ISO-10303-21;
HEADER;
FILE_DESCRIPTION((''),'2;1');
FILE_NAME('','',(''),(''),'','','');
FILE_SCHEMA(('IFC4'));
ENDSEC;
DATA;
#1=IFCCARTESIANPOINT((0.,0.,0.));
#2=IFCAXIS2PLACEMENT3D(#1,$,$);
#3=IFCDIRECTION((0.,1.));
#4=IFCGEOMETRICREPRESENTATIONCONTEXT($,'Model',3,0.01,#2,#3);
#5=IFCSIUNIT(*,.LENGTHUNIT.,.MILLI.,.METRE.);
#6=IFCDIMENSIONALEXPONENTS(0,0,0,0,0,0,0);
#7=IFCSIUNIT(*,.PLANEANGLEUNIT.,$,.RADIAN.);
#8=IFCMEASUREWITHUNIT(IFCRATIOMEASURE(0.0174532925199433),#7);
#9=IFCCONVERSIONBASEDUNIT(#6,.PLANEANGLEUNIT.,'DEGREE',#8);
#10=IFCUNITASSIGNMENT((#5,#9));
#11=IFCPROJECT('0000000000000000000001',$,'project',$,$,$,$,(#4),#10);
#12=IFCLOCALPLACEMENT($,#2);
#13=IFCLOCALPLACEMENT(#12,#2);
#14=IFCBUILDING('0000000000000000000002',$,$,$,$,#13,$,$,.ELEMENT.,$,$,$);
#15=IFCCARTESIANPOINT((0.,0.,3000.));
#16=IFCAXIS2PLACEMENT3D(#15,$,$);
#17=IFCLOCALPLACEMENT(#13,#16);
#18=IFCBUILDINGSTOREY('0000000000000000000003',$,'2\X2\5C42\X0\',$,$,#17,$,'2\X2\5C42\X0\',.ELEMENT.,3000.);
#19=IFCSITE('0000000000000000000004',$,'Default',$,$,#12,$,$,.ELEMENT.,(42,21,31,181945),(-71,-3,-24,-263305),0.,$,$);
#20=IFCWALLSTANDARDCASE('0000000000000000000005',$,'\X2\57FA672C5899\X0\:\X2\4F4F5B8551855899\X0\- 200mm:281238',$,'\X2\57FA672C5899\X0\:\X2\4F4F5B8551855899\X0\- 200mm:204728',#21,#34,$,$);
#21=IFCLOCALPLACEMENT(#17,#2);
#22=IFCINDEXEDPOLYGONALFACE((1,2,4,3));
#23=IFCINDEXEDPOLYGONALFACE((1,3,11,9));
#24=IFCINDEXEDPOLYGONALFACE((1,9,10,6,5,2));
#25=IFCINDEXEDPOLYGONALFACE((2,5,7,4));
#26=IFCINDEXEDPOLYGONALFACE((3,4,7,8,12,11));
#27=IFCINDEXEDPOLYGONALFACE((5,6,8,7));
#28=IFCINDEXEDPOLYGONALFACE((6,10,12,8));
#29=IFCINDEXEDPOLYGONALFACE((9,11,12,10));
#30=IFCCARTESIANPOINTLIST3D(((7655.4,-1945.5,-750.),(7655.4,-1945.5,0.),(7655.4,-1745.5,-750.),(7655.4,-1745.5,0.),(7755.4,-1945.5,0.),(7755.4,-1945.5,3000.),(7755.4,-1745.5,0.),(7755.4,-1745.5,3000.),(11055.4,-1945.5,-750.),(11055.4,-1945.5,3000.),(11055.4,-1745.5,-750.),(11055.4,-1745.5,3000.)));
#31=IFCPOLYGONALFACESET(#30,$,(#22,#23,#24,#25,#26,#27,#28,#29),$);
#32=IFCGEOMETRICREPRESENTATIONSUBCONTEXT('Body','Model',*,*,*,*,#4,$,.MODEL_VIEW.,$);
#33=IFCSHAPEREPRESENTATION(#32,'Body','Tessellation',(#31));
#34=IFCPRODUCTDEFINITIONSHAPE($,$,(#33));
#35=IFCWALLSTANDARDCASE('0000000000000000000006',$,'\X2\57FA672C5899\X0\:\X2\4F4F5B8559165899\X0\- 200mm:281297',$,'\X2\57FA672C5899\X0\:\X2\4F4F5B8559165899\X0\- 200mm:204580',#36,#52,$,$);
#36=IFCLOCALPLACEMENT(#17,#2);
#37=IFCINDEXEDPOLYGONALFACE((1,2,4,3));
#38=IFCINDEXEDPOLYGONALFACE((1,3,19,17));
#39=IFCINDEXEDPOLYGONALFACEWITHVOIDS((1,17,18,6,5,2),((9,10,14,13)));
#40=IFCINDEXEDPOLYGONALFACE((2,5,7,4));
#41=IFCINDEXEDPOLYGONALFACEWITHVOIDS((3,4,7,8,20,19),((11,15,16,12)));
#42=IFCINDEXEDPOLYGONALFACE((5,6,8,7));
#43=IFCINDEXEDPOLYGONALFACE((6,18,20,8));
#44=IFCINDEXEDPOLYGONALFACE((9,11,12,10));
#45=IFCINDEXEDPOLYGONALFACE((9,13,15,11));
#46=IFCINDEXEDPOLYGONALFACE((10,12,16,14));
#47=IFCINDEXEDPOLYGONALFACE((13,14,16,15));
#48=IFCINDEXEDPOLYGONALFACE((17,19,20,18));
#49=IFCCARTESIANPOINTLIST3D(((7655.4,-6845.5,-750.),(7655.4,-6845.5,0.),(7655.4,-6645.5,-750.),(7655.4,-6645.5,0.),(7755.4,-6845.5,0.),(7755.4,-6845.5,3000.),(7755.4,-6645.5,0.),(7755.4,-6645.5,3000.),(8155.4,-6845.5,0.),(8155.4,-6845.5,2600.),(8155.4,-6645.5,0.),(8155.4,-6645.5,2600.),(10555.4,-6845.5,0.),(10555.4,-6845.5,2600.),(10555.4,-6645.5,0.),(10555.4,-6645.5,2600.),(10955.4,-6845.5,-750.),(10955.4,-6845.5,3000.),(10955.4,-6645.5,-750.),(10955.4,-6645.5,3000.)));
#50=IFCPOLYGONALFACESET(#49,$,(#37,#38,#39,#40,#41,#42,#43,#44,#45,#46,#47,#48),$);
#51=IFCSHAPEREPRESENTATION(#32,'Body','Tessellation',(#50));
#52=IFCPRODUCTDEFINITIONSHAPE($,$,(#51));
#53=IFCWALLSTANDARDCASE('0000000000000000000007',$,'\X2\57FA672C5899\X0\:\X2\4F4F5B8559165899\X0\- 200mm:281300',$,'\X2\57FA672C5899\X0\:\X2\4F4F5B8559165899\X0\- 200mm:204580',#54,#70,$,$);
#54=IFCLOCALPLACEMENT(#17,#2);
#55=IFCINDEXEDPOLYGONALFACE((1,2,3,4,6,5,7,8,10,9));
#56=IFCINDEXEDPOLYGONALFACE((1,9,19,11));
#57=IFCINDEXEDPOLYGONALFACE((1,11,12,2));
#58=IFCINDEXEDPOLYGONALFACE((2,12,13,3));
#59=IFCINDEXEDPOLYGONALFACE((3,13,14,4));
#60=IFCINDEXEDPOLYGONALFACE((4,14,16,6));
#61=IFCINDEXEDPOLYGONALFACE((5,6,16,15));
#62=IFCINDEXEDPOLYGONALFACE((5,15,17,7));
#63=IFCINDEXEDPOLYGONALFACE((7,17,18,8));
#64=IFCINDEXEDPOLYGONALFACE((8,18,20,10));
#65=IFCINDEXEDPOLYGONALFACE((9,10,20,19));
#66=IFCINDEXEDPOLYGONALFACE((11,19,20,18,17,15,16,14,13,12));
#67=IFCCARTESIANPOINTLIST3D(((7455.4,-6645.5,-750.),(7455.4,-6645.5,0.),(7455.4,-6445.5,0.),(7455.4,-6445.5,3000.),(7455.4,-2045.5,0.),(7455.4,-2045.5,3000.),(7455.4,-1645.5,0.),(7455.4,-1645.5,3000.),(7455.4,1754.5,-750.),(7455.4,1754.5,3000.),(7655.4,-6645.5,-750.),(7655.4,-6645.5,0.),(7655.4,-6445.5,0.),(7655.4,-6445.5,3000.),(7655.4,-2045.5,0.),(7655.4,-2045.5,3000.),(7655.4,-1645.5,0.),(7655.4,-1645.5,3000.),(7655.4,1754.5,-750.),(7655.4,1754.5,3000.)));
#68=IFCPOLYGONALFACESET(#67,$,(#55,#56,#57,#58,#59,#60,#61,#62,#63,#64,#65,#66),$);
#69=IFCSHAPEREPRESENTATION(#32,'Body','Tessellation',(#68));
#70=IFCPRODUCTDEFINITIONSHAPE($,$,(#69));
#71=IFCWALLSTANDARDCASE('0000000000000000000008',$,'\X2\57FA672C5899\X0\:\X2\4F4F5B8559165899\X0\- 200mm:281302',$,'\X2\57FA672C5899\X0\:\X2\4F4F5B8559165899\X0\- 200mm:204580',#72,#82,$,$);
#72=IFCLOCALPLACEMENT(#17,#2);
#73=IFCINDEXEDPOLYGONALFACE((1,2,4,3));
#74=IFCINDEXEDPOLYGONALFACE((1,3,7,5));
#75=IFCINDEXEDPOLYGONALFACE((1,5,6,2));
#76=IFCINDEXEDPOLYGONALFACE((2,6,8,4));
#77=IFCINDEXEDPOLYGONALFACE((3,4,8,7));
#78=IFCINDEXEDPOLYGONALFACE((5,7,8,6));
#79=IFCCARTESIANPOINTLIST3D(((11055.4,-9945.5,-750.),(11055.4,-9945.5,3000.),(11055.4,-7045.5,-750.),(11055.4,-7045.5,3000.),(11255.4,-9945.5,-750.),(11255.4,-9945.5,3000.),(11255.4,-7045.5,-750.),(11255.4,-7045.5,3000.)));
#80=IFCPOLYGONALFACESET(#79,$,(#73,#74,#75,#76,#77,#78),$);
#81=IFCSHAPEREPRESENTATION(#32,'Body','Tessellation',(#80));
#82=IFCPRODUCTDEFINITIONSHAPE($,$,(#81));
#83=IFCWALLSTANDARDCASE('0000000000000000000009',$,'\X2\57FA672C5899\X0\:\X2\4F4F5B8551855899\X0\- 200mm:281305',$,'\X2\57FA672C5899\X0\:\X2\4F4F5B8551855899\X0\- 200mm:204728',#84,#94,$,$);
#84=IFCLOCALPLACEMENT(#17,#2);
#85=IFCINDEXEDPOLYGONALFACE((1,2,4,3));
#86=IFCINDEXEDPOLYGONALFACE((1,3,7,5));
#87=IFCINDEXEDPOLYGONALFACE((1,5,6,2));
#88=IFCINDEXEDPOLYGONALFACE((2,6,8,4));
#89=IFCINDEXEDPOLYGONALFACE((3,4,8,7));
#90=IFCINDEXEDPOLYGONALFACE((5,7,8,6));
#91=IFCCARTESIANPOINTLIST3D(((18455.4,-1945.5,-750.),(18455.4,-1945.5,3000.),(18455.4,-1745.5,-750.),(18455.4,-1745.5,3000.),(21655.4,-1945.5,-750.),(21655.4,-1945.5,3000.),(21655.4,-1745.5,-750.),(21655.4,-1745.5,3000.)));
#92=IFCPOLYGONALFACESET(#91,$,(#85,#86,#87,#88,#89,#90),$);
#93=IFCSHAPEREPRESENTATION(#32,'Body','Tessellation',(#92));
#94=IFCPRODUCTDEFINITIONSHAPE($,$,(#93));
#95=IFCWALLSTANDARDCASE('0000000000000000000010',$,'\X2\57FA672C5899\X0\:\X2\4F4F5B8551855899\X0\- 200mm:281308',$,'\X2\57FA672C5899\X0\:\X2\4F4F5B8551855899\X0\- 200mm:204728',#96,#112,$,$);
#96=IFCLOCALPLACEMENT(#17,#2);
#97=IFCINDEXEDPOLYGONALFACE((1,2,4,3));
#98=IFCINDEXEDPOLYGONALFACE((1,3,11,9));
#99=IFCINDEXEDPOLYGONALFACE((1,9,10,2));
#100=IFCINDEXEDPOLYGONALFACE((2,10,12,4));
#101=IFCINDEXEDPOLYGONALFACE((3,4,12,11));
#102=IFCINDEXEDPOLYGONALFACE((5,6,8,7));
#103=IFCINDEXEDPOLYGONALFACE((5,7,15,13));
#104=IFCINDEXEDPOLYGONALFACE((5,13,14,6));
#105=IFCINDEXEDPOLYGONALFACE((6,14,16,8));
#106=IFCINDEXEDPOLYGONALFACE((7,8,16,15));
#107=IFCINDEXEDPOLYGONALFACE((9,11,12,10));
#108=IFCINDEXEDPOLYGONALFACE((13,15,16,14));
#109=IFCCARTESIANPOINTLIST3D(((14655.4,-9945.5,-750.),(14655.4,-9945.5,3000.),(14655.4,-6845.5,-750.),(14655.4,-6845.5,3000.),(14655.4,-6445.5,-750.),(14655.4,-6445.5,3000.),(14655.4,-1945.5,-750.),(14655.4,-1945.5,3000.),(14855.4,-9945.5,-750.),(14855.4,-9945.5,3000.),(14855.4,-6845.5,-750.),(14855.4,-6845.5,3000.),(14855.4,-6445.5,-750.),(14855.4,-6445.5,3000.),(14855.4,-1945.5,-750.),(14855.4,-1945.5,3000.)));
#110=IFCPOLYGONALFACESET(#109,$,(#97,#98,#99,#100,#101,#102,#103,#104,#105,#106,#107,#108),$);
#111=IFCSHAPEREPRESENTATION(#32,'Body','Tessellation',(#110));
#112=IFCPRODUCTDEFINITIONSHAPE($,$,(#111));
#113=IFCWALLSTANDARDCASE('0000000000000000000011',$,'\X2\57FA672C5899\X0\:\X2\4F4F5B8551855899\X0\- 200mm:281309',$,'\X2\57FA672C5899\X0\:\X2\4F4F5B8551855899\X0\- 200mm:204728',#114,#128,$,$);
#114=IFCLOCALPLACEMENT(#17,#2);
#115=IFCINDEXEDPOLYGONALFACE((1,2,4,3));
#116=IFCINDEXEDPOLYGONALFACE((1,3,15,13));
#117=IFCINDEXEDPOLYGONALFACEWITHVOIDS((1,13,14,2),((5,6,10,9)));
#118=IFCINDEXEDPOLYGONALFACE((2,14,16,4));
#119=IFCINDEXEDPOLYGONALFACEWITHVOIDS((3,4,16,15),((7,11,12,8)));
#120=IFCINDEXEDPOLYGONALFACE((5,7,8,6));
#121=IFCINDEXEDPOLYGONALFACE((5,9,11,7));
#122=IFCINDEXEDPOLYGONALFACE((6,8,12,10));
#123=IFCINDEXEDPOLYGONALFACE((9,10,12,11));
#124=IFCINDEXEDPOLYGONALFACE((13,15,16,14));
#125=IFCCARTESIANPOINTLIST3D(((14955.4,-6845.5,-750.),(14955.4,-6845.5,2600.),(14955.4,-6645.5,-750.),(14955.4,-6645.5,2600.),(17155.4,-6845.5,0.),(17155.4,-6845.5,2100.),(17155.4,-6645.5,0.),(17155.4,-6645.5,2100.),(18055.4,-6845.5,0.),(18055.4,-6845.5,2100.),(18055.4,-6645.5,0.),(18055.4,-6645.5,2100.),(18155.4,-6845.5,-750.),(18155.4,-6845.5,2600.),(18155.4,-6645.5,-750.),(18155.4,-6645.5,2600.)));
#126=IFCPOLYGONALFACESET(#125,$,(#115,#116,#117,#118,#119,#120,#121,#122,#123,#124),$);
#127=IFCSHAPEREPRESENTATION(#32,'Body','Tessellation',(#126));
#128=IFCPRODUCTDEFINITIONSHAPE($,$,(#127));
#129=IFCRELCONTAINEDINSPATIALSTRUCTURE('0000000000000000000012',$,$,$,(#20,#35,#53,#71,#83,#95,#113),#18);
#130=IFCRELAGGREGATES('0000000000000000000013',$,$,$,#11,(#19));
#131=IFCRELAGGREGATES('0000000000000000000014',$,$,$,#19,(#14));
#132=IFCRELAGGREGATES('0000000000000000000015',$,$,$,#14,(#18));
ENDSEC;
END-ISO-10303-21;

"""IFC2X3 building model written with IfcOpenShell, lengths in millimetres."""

from ifc_helpers import new_model, entity, si_unit, converted_unit, direction, frame, frame_2d, origin, place, context, subcontext, project, spatial, polyline, rectangle, extrude, clip, bounded_halfspace, element, save


model = new_model("IFC2X3")

# Units and contexts
model_context = context("Model", 3, precision=0.01, world=origin(), true_north=direction((0.0, 1.0)))
body_context = subcontext(model_context, "Body", "Model", "MODEL_VIEW")
ifc_project = project(units=[si_unit("LENGTHUNIT", "METRE", prefix="MILLI"), converted_unit("PLANEANGLEUNIT", "DEGREE", entity("IfcRatioMeasure", 0.0174532925199433), si_unit("PLANEANGLEUNIT", "RADIAN"), dimensions=[0, 0, 0, 0, 0, 0, 0])], contexts=[model_context])

# Site, building, storey
site_placement = place(None, origin())
site = spatial("IfcSite", under=ifc_project, at=site_placement, Name="Default", CompositionType="ELEMENT", RefLatitude=(42, 21, 31, 181945), RefLongitude=(-71, -3, -24, -263305), RefElevation=0.0)
building_placement = place(site_placement, origin())
building = spatial("IfcBuilding", under=site, at=building_placement, CompositionType="ELEMENT")
storey_placement = place(building_placement, frame((0.0, 0.0, 3000.0)))
storey = spatial("IfcBuildingStorey", under=building, at=storey_placement, Name="2层", LongName="2层", CompositionType="ELEMENT", Elevation=3000.0)

# Wall
wall_1_placement = place(storey_placement, frame((11055.4, -1845.5, -750.0), z_axis=(0.0, 0.0, 1.0), x_axis=(-1.0, 0.0, 0.0)))
element("IfcWallStandardCase", 1, at=wall_1_placement, inside=storey, Name="基本墙:住宅内墙- 200mm:281238", ObjectType="基本墙:住宅内墙- 200mm:204728", context=body_context, shape_type="Clipping", body=[
    clip(clip(extrude(rectangle(XDim=3400.0, YDim=200.0, at=frame_2d((1700.0, 0.0), x_axis=(-1.0, 0.0))), origin(), (0.0, 0.0, 1.0), 3750.0), bounded_halfspace(frame((3300.0, 100.0, 750.0), z_axis=(0.0, 0.0, -1.0), x_axis=(-1.0, 0.0, 0.0)), True, frame((3300.0, 100.0, 750.0), z_axis=(0.0, 0.0, -1.0), x_axis=(-1.0, 0.0, 0.0)), polyline([(0.0, 0.0), (-100.0, 0.0), (-100.0, -200.0), (0.0, -200.0), (0.0, 0.0)]))), bounded_halfspace(frame((3300.0, -100.0, 750.0), z_axis=(-1.0, 0.0, 0.0), x_axis=(0.0, 0.0, -1.0)), True, frame((3300.0, -100.0, 750.0), z_axis=(-1.0, 0.0, 0.0), x_axis=(0.0, 0.0, -1.0)), polyline([(0.0, 0.0), (-3000.0, 0.0), (-3000.0, -200.0), (0.0, -200.0), (0.0, 0.0)]))),
])

# Wall, opening
wall_2_placement = place(storey_placement, frame((7655.4, -6745.5, -750.0)))
wall_2 = element("IfcWallStandardCase", 2, at=wall_2_placement, inside=storey, Name="基本墙:住宅外墙- 200mm:281297", ObjectType="基本墙:住宅外墙- 200mm:204580", context=body_context, shape_type="Clipping", body=[
    clip(clip(clip(extrude(rectangle(XDim=3300.0, YDim=200.0, at=frame_2d((1650.0, 0.0), x_axis=(-1.0, 0.0))), origin(), (0.0, 0.0, 1.0), 3750.0), bounded_halfspace(frame((3300.0, -100.0, 3750.0), z_axis=(-1.0, 0.0, 0.0), x_axis=(0.0, 0.0, -1.0)), True, frame((3300.0, -100.0, 3750.0), z_axis=(-1.0, 0.0, 0.0), x_axis=(0.0, 0.0, -1.0)), polyline([(0.0, 0.0), (0.0, -200.0), (3750.0, -200.0), (3750.0, 0.0), (0.0, 0.0)]))), bounded_halfspace(frame((100.0, -100.0, 750.0), z_axis=(0.0, 0.0, -1.0), x_axis=(1.0, 0.0, 0.0)), True, frame((100.0, -100.0, 750.0), z_axis=(0.0, 0.0, -1.0), x_axis=(1.0, 0.0, 0.0)), polyline([(0.0, 0.0), (-100.0, 0.0), (-100.0, -200.0), (0.0, -200.0), (0.0, 0.0)]))), bounded_halfspace(frame((100.0, 100.0, 750.0), z_axis=(1.0, 0.0, 0.0), x_axis=(0.0, 0.0, -1.0)), True, frame((100.0, 100.0, 750.0), z_axis=(1.0, 0.0, 0.0), x_axis=(0.0, 0.0, -1.0)), polyline([(0.0, 0.0), (-3000.0, 0.0), (-3000.0, -200.0), (0.0, -200.0), (0.0, 0.0)]))),
])
opening_1_placement = place(wall_2_placement, origin())
element("IfcOpeningElement", 3, at=opening_1_placement, cuts=wall_2, ObjectType="Opening", context=body_context, shape_type="SweptSolid", body=[
    extrude(rectangle(XDim=2600.0, YDim=2400.0, at=frame_2d((0.0, 0.0), x_axis=(0.0, 1.0))), frame((1700.0, -1424.0, 2050.0), z_axis=(0.0, 1.0, 0.0), x_axis=(-1.0, 0.0, 0.0)), (0.0, 0.0, 1.0), 3048.0),
])

# Wall
wall_3_placement = place(storey_placement, frame((7555.4, 1754.5, -750.0), z_axis=(0.0, 0.0, 1.0), x_axis=(0.0, -1.0, 0.0)))
element("IfcWallStandardCase", 4, at=wall_3_placement, inside=storey, Name="基本墙:住宅外墙- 200mm:281300", ObjectType="基本墙:住宅外墙- 200mm:204580", context=body_context, shape_type="Clipping", body=[
    clip(clip(clip(extrude(rectangle(XDim=8400.0, YDim=200.0, at=frame_2d((4200.0, 0.0), x_axis=(-1.0, 0.0))), origin(), (0.0, 0.0, 1.0), 3750.0), bounded_halfspace(frame((3400.0, 100.0, 750.0), z_axis=(0.0, 0.0, -1.0), x_axis=(0.0, 1.0, 0.0)), True, frame((3400.0, 100.0, 750.0), z_axis=(0.0, 0.0, -1.0), x_axis=(0.0, 1.0, 0.0)), polyline([(0.0, 0.0), (0.0, 100.0), (0.0, 300.0), (0.0, 400.0), (-200.0, 400.0), (-200.0, 0.0), (0.0, 0.0)]))), bounded_halfspace(frame((8200.0, 100.0, 750.0), z_axis=(0.0, 0.0, -1.0), x_axis=(0.0, 1.0, 0.0)), True, frame((8200.0, 100.0, 750.0), z_axis=(0.0, 0.0, -1.0), x_axis=(0.0, 1.0, 0.0)), polyline([(0.0, 0.0), (0.0, 200.0), (-200.0, 200.0), (-200.0, 0.0), (0.0, 0.0)]))), bounded_halfspace(frame((8200.0, -100.0, 750.0), z_axis=(-1.0, 0.0, 0.0), x_axis=(0.0, 0.0, -1.0)), True, frame((8200.0, -100.0, 750.0), z_axis=(-1.0, 0.0, 0.0), x_axis=(0.0, 0.0, -1.0)), polyline([(0.0, 0.0), (-3000.0, 0.0), (-3000.0, -200.0), (0.0, -200.0), (0.0, 0.0)]))),
])

# Walls
wall_4_placement = place(storey_placement, frame((11155.4, -7045.5, -750.0), z_axis=(0.0, 0.0, 1.0), x_axis=(0.0, -1.0, 0.0)))
element("IfcWallStandardCase", 5, at=wall_4_placement, inside=storey, Name="基本墙:住宅外墙- 200mm:281302", ObjectType="基本墙:住宅外墙- 200mm:204580", context=body_context, shape_type="Clipping", body=[
    clip(clip(extrude(rectangle(XDim=2900.0, YDim=200.0, at=frame_2d((1450.0, 0.0), x_axis=(-1.0, 0.0))), origin(), (0.0, 0.0, 1.0), 3750.0), bounded_halfspace(frame((0.0, -100.0, 0.0), z_axis=(1.0, 0.0, 0.0), x_axis=(0.0, 0.0, -1.0)), True, frame((0.0, -100.0, 0.0), z_axis=(1.0, 0.0, 0.0), x_axis=(0.0, 0.0, -1.0)), polyline([(0.0, 0.0), (0.0, 200.0), (-3750.0, 200.0), (-3750.0, 0.0), (0.0, 0.0)]))), bounded_halfspace(frame((2900.0, -100.0, 3750.0), z_axis=(-1.0, 0.0, 0.0), x_axis=(0.0, 0.0, -1.0)), True, frame((2900.0, -100.0, 3750.0), z_axis=(-1.0, 0.0, 0.0), x_axis=(0.0, 0.0, -1.0)), polyline([(0.0, 0.0), (0.0, -200.0), (3750.0, -200.0), (3750.0, 0.0), (0.0, 0.0)]))),
])
wall_5_placement = place(storey_placement, frame((21655.4, -1845.5, -750.0), z_axis=(0.0, 0.0, 1.0), x_axis=(-1.0, 0.0, 0.0)))
element("IfcWallStandardCase", 6, at=wall_5_placement, inside=storey, Name="基本墙:住宅内墙- 200mm:281305", ObjectType="基本墙:住宅内墙- 200mm:204728", context=body_context, shape_type="Clipping", body=[
    clip(extrude(rectangle(XDim=3200.0, YDim=200.0, at=frame_2d((1600.0, 0.0), x_axis=(-1.0, 0.0))), origin(), (0.0, 0.0, 1.0), 3750.0), bounded_halfspace(frame((0.0, -100.0, 0.0), z_axis=(-1.0, 0.0, 0.0), x_axis=(0.0, 0.0, -1.0)), False, frame((0.0, -100.0, 0.0), z_axis=(-1.0, 0.0, 0.0), x_axis=(0.0, 0.0, -1.0)), polyline([(0.0, 0.0), (-3750.0, 0.0), (-3750.0, -200.0), (0.0, -200.0), (0.0, 0.0)]))),
])

# Walls, openings
wall_6_placement = place(storey_placement, frame((14755.4, -1945.5, -750.0), z_axis=(0.0, 0.0, 1.0), x_axis=(0.0, -1.0, 0.0)))
wall_6 = element("IfcWallStandardCase", 7, at=wall_6_placement, inside=storey, Name="基本墙:住宅内墙- 200mm:281308", ObjectType="基本墙:住宅内墙- 200mm:204728", context=body_context, shape_type="Clipping", body=[
    clip(extrude(rectangle(XDim=8000.0, YDim=200.0, at=frame_2d((4000.0, 0.0), x_axis=(-1.0, 0.0))), origin(), (0.0, 0.0, 1.0), 3750.0), bounded_halfspace(frame((8000.0, -100.0, 3750.0), z_axis=(1.0, 0.0, 0.0), x_axis=(0.0, 0.0, -1.0)), False, frame((8000.0, -100.0, 3750.0), z_axis=(1.0, 0.0, 0.0), x_axis=(0.0, 0.0, -1.0)), polyline([(0.0, 0.0), (3750.0, 0.0), (3750.0, 200.0), (0.0, 200.0), (0.0, 0.0)]))),
])
opening_2_placement = place(storey_placement, frame((14755.4, -1945.5, -750.0), z_axis=(0.0, 0.0, 1.0), x_axis=(0.0, -1.0, 0.0)))
element("IfcOpeningElement", 8, at=opening_2_placement, cuts=wall_6, ObjectType="Opening", context=body_context, shape_type="SweptSolid", body=[
    extrude(rectangle(XDim=3750.0, YDim=200.0, at=frame_2d((0.0, 0.0), x_axis=(1.0, 0.0))), frame((4900.0, 0.0, 1875.0), z_axis=(-1.0, 0.0, 0.0), x_axis=(0.0, 0.0, 1.0)), (0.0, 0.0, 1.0), 400.0),
])
wall_7_placement = place(storey_placement, frame((18155.4, -6745.5, -750.0), z_axis=(0.0, 0.0, 1.0), x_axis=(-1.0, 0.0, 0.0)))
wall_7 = element("IfcWallStandardCase", 9, at=wall_7_placement, inside=storey, Name="基本墙:住宅内墙- 200mm:281309", ObjectType="基本墙:住宅内墙- 200mm:204728", context=body_context, shape_type="Clipping", body=[
    clip(clip(clip(extrude(rectangle(XDim=3200.0, YDim=200.0, at=frame_2d((1600.0, 0.0), x_axis=(-1.0, 0.0))), origin(), (0.0, 0.0, 1.0), 3350.0), bounded_halfspace(frame((0.0, 100.0, 0.0), z_axis=(-1.0, 0.0, 0.0), x_axis=(0.0, 0.0, -1.0)), False, frame((0.0, 100.0, 0.0), z_axis=(-1.0, 0.0, 0.0), x_axis=(0.0, 0.0, -1.0)), polyline([(0.0, 0.0), (0.0, 200.0), (-3350.0, 200.0), (-3350.0, 0.0), (0.0, 0.0)]))), bounded_halfspace(frame((3200.0, -100.0, 0.0), z_axis=(1.0, 0.0, 0.0), x_axis=(0.0, 0.0, -1.0)), False, frame((3200.0, -100.0, 0.0), z_axis=(1.0, 0.0, 0.0), x_axis=(0.0, 0.0, -1.0)), polyline([(0.0, 0.0), (0.0, 200.0), (-3350.0, 200.0), (-3350.0, 0.0), (0.0, 0.0)]))), bounded_halfspace(frame((0.0, -100.0, 3350.0), z_axis=(0.0, 0.0, 1.0), x_axis=(-1.0, 0.0, 0.0)), False, frame((0.0, -100.0, 3350.0), z_axis=(0.0, 0.0, 1.0), x_axis=(-1.0, 0.0, 0.0)), polyline([(0.0, 0.0), (-3200.0, 0.0), (-3200.0, -200.0), (0.0, -200.0), (0.0, 0.0)]))),
])
opening_3_placement = place(wall_7_placement, origin())
element("IfcOpeningElement", 10, at=opening_3_placement, cuts=wall_7, ObjectType="Opening", context=body_context, shape_type="SweptSolid", body=[
    extrude(rectangle(XDim=2100.0, YDim=900.0, at=frame_2d((0.0, 0.0), x_axis=(1.0, 0.0))), frame((550.0, -1624.0, 1800.0), z_axis=(0.0, 1.0, 0.0), x_axis=(0.0, 0.0, 1.0)), (0.0, 0.0, 1.0), 3048.0),
])

save(model, "model.ifc")
